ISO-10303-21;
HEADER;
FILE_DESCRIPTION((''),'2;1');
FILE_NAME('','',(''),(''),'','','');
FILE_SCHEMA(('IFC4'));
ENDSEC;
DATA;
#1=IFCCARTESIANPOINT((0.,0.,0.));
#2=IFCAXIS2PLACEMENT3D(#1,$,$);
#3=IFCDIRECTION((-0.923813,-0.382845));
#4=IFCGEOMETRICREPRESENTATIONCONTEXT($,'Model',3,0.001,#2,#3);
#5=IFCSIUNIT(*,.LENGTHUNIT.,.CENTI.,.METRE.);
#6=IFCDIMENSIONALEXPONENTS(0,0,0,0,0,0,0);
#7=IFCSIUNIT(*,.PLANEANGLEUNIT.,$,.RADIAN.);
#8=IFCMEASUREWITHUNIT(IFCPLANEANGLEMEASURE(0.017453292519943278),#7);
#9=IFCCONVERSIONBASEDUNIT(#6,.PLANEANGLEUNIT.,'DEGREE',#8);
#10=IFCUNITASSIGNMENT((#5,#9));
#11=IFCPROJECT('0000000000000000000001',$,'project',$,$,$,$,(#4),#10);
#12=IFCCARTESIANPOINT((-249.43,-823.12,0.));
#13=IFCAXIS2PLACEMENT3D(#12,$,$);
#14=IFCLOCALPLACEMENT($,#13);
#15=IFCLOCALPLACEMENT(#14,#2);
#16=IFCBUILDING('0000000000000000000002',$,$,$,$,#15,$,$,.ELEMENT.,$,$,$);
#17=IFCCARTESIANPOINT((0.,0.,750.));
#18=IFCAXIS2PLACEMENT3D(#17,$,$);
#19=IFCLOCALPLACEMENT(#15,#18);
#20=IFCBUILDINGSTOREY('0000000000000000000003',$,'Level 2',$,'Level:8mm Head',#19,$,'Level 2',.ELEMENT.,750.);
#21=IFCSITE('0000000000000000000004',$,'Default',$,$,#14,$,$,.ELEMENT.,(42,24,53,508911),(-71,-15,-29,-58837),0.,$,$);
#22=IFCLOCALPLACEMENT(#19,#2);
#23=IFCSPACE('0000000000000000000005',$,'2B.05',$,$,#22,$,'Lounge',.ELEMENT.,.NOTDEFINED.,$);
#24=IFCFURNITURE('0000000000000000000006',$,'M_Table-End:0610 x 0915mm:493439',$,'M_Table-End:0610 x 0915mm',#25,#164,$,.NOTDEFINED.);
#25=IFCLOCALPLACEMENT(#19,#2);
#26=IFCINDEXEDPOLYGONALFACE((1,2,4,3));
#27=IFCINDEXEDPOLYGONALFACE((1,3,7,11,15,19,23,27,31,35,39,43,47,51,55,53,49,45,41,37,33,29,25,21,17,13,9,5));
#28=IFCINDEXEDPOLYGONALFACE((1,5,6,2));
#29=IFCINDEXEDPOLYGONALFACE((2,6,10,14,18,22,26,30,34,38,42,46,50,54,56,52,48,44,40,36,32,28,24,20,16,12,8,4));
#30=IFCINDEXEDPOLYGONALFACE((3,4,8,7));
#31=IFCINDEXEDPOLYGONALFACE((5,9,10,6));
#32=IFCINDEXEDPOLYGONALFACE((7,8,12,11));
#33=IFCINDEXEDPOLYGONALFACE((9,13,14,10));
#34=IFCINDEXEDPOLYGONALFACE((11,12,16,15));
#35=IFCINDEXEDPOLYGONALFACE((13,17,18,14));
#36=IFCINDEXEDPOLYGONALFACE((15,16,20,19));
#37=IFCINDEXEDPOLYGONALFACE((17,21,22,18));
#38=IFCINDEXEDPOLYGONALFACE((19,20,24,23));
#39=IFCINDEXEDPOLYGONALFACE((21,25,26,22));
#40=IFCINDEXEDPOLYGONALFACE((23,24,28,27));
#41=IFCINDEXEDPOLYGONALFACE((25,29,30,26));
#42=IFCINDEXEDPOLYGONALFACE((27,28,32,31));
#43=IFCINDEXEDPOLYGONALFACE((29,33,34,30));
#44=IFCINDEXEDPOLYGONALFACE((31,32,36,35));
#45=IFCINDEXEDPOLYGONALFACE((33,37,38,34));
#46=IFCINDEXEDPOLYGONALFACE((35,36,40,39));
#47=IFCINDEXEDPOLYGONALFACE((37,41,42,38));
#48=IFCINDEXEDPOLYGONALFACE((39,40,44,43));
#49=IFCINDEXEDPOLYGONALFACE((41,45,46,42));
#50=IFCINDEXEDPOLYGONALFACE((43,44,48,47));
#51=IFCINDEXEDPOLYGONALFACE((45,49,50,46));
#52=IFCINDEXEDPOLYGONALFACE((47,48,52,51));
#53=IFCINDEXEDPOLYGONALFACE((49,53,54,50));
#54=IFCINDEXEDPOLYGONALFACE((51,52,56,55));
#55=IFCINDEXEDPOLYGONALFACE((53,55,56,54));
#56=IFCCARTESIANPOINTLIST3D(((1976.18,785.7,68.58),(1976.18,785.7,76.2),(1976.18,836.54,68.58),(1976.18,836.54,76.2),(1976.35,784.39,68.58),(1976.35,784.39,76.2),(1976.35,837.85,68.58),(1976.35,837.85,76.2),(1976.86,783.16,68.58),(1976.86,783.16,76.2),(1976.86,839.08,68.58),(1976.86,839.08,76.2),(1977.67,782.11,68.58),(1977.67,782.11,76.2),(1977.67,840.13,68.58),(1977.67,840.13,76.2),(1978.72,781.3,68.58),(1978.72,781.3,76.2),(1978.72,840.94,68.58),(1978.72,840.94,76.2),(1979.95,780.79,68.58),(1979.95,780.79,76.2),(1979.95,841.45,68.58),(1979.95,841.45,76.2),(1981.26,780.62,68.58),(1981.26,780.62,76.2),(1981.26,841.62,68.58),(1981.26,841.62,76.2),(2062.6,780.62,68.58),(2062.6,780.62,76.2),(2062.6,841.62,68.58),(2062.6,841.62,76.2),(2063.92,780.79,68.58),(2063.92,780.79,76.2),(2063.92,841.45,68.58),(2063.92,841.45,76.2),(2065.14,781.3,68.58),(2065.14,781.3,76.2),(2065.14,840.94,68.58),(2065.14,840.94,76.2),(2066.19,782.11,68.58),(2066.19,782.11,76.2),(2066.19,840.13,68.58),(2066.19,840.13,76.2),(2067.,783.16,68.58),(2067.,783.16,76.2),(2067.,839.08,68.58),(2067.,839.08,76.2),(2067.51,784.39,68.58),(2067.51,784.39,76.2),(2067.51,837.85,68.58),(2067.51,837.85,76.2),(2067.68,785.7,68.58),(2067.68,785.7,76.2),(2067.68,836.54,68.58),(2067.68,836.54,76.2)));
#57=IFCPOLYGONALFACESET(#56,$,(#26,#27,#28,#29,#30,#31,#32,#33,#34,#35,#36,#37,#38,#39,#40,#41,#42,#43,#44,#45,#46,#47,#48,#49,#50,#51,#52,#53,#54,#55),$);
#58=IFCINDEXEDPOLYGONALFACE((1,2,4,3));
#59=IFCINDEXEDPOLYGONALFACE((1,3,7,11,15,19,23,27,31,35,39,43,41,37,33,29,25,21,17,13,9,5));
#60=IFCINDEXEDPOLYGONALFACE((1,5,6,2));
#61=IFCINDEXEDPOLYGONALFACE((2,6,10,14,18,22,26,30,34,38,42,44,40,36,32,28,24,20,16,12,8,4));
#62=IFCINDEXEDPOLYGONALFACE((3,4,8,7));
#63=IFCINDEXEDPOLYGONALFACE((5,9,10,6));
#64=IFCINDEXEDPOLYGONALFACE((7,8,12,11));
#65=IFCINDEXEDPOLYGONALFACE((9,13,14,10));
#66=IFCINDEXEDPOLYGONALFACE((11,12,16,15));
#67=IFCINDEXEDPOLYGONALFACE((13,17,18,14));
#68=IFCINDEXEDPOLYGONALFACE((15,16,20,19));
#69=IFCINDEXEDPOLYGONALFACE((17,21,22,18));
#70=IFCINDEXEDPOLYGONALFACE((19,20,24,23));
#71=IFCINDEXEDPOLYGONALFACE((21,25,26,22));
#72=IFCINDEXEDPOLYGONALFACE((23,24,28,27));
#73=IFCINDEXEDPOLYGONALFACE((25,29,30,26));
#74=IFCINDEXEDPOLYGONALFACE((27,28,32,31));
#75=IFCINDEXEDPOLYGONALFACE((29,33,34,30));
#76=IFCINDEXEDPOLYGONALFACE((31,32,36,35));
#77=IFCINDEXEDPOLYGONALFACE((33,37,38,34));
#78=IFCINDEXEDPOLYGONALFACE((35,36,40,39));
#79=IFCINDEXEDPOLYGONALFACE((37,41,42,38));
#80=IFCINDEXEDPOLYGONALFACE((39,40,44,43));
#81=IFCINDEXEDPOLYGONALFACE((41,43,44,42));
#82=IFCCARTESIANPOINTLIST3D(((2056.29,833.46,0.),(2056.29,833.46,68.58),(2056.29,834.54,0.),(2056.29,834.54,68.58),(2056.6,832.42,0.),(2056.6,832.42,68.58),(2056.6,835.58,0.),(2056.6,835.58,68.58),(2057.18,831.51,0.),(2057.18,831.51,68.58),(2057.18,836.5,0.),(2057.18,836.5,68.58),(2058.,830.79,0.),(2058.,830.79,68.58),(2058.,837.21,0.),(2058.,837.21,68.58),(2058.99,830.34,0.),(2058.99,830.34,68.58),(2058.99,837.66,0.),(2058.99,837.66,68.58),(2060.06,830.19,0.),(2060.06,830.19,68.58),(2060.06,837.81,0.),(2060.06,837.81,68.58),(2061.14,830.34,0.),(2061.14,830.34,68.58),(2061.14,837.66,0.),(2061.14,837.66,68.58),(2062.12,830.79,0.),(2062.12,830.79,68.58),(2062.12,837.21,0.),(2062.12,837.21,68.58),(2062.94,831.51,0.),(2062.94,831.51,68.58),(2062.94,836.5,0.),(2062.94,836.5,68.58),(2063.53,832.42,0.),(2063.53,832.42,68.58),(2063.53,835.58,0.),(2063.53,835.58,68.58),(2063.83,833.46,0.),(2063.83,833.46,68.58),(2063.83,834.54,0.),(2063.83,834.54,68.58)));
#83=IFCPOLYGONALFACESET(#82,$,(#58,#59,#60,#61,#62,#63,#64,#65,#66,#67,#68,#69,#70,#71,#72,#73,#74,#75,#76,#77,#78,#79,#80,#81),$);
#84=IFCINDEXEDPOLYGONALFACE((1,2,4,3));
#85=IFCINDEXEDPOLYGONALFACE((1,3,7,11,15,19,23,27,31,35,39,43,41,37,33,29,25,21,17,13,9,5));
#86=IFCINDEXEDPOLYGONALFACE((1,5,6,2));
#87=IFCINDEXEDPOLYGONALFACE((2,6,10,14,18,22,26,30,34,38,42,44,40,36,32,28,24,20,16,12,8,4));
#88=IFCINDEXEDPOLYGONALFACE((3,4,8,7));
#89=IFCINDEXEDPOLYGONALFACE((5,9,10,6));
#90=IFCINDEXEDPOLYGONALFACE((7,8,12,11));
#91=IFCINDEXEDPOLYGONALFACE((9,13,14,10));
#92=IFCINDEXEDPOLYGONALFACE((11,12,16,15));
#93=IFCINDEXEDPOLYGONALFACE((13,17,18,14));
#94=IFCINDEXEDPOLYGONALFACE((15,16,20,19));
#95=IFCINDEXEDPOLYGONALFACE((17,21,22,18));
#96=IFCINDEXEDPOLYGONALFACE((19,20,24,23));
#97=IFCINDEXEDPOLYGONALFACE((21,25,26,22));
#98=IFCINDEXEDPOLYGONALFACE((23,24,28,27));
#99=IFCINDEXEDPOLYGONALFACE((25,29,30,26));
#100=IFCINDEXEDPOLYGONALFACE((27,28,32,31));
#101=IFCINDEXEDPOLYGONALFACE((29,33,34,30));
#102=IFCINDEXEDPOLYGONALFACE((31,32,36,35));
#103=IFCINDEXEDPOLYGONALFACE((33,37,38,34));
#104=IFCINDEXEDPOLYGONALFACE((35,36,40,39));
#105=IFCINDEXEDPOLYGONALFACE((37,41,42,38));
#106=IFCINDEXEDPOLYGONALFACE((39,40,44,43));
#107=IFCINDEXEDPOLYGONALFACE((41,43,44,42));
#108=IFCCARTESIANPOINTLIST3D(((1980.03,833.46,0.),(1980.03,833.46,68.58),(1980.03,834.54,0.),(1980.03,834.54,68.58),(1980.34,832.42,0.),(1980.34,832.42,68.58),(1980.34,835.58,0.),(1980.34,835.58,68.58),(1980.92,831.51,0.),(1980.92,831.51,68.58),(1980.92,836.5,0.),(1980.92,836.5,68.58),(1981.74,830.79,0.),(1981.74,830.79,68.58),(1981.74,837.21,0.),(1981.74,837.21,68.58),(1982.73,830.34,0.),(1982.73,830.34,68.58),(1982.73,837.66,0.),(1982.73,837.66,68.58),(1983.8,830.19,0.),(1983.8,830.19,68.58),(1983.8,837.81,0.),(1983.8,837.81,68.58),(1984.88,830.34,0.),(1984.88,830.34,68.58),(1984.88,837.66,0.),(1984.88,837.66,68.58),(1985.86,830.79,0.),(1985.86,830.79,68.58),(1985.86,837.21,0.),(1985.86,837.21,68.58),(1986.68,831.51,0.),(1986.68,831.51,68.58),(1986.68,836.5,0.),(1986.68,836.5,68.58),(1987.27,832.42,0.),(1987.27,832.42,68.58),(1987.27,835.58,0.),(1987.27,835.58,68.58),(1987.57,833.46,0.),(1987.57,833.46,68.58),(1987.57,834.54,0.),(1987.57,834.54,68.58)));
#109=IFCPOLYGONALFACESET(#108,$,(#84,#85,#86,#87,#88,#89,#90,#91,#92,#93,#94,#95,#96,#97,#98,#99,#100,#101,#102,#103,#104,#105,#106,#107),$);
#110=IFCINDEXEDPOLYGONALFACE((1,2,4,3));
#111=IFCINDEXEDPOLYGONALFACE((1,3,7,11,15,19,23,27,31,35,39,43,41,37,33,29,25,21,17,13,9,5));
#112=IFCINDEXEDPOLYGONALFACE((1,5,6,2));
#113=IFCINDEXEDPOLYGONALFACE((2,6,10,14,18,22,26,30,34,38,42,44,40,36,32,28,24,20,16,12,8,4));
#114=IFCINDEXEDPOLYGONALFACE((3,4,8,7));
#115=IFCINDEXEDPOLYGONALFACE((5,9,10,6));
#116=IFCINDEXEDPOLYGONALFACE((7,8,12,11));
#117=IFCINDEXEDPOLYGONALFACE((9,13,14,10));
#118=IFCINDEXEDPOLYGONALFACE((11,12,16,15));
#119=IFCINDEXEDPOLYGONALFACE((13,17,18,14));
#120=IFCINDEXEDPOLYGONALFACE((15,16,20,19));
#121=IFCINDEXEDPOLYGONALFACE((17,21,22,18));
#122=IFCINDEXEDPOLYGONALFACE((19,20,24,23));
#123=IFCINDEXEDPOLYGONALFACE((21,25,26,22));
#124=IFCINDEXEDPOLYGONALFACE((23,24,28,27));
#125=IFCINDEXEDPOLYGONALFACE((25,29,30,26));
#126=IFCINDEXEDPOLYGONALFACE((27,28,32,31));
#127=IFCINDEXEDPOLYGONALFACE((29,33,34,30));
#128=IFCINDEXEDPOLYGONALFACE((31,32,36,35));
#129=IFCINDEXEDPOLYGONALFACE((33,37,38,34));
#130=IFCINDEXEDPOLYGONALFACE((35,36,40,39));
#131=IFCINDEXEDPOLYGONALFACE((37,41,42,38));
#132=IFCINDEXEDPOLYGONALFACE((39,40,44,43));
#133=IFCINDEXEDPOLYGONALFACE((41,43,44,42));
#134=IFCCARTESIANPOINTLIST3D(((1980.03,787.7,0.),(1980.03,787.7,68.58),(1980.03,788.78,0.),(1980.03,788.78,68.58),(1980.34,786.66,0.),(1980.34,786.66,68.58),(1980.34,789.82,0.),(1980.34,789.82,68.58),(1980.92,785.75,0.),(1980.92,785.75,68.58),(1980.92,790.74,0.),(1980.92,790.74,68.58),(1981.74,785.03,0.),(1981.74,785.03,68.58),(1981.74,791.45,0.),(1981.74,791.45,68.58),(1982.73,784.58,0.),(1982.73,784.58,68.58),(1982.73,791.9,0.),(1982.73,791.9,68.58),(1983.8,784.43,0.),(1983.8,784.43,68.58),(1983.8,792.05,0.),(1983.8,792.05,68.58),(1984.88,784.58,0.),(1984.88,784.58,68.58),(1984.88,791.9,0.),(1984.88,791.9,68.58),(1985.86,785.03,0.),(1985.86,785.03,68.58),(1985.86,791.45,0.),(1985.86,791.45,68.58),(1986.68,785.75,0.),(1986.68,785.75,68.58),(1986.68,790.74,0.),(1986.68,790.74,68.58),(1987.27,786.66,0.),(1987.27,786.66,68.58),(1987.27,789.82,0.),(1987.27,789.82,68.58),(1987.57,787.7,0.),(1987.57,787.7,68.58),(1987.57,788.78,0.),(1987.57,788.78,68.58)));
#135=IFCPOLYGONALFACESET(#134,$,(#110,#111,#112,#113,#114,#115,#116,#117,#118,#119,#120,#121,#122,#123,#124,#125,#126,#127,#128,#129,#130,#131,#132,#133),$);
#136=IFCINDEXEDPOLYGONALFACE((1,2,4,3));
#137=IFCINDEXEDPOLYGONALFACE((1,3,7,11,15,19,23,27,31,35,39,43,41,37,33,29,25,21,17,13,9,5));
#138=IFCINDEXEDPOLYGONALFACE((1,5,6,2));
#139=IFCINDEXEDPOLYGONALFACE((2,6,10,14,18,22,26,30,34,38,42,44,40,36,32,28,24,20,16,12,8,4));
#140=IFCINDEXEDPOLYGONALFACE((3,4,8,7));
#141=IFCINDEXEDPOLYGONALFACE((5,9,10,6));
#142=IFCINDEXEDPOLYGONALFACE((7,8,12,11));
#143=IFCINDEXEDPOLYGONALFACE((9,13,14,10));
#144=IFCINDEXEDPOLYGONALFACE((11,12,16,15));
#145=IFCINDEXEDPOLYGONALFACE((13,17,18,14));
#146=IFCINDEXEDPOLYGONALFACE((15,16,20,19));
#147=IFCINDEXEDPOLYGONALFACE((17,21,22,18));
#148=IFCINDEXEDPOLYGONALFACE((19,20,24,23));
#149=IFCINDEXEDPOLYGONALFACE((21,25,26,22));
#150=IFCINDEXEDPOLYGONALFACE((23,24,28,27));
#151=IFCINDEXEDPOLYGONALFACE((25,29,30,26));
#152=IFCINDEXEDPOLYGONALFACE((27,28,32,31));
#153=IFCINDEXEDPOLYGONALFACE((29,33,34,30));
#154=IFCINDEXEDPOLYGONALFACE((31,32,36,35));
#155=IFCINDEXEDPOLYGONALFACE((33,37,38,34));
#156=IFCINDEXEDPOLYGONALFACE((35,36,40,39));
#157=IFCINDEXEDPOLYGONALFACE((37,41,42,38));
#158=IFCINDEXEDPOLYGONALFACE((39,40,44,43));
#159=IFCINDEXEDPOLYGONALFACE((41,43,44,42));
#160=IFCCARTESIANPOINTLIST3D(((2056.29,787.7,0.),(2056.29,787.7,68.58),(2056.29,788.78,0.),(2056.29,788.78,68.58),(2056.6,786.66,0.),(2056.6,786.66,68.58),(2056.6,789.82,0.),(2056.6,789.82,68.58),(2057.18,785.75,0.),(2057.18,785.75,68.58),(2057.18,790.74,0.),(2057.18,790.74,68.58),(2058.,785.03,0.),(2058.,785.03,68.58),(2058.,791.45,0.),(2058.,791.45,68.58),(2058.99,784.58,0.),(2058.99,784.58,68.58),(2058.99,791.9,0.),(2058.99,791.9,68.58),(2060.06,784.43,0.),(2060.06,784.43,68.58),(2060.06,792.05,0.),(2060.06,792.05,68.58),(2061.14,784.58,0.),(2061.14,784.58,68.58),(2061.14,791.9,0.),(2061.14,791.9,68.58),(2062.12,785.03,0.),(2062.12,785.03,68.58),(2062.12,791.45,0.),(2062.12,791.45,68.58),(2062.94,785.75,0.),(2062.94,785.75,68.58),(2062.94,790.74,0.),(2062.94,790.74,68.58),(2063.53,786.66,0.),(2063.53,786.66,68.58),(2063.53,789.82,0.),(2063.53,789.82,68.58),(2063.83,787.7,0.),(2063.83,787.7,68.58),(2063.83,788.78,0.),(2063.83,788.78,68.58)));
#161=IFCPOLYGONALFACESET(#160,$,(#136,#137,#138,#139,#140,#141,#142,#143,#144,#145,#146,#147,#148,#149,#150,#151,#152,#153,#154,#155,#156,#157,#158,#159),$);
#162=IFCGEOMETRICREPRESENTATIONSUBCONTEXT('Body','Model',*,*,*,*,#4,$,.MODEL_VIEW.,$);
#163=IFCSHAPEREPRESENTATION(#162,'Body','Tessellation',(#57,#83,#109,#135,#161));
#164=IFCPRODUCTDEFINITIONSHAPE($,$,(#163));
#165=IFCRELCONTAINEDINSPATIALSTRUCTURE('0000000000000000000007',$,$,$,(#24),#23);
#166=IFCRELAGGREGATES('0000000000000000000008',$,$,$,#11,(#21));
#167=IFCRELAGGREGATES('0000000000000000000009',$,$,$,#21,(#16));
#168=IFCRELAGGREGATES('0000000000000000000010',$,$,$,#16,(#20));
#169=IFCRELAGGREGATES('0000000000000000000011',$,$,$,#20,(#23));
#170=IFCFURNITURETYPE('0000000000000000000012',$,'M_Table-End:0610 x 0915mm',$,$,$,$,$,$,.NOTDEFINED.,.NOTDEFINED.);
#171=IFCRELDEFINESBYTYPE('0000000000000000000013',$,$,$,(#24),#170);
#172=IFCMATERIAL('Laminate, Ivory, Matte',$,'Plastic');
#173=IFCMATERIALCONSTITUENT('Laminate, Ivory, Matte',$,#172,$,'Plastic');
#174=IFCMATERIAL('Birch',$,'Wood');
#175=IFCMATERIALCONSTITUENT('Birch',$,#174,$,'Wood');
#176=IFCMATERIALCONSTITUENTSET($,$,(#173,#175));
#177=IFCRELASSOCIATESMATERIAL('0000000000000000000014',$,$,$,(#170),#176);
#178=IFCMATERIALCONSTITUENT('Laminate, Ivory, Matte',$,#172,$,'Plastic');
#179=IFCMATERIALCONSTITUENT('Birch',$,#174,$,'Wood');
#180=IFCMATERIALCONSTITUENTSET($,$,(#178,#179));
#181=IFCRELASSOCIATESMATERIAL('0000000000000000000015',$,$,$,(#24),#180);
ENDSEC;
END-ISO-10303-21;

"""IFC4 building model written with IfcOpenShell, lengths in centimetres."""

from ifc_helpers import new_model, entity, si_unit, converted_unit, direction, frame, origin, place, context, subcontext, project, spatial, line, arc, indexed_curve, outline, extrude, source, transform, mapped, material, constituent, constituent_set, type_object, type_shapes, element, save


model = new_model("IFC4")

# Units and contexts
model_context = context("Model", 3, precision=0.001, world=origin(), true_north=direction((-0.923813, -0.382845)))
body_context = subcontext(model_context, "Body", "Model", "MODEL_VIEW")
ifc_project = project(units=[si_unit("LENGTHUNIT", "METRE", prefix="CENTI"), converted_unit("PLANEANGLEUNIT", "DEGREE", entity("IfcPlaneAngleMeasure", 0.017453292519943278), si_unit("PLANEANGLEUNIT", "RADIAN"), dimensions=[0, 0, 0, 0, 0, 0, 0])], contexts=[model_context])

# Site, building, storey
site_placement = place(None, frame((-249.43, -823.12, 0.0)))
site = spatial("IfcSite", under=ifc_project, at=site_placement, Name="Default", CompositionType="ELEMENT", RefLatitude=(42, 24, 53, 508911), RefLongitude=(-71, -15, -29, -58837), RefElevation=0.0)
building_placement = place(site_placement, origin())
building = spatial("IfcBuilding", under=site, at=building_placement, CompositionType="ELEMENT")
storey_placement = place(building_placement, frame((0.0, 0.0, 750.0)))
storey = spatial("IfcBuildingStorey", under=building, at=storey_placement, Name="Level 2", ObjectType="Level:8mm Head", LongName="Level 2", CompositionType="ELEMENT", Elevation=750.0)

# Shared definitions
space_1_placement = place(storey_placement, origin())
space_1 = spatial("IfcSpace", under=storey, at=space_1_placement, Name="2B.05", LongName="Lounge", CompositionType="ELEMENT", PredefinedType="NOTDEFINED")

# Furniture
ifc_material_1 = material(Name="Laminate, Ivory, Matte", Category="Plastic")
ifc_constituent_1 = constituent(ifc_material_1, Name="Laminate, Ivory, Matte", Category="Plastic")
ifc_material_2 = material(Name="Birch", Category="Wood")
ifc_constituent_2 = constituent(ifc_material_2, Name="Birch", Category="Wood")
ifc_constituent_set_1 = constituent_set(constituents=[ifc_constituent_1, ifc_constituent_2])
ifc_constituent_3 = constituent(ifc_material_1, Name="Laminate, Ivory, Matte", Category="Plastic")
ifc_constituent_4 = constituent(ifc_material_2, Name="Birch", Category="Wood")
ifc_constituent_set_2 = constituent_set(constituents=[ifc_constituent_3, ifc_constituent_4])
furniture_type_1 = type_object("IfcFurnitureType", Name="M_Table-End:0610 x 0915mm", AssemblyPlace="NOTDEFINED", PredefinedType="NOTDEFINED", material=ifc_constituent_set_2)
shared_shape_1 = source(origin(), body_context, "Body", "SweptSolid", [
    extrude(outline(indexed_curve([(25.42, -45.75), (29.01, -44.26), (30.5, -40.67), (30.5, 40.67), (29.01, 44.26), (25.42, 45.75), (-25.42, 45.75), (-29.01, 44.26), (-30.5, 40.67), (-30.5, -40.67), (-29.01, -44.26), (-25.42, -45.75)], segments=[arc(1, 2, 3), line(3, 4), arc(4, 5, 6), line(6, 7), arc(7, 8, 9), line(9, 10), arc(10, 11, 12), line(12, 1)], self_intersect=False)), frame((30.87, 15.24, -381.42)), (0.0, 0.0, 1.0), 7.62),
    extrude(outline(indexed_curve([(-3.81, 0.0), (0.0, -3.81), (3.81, 0.0), (0.0, 3.81)], segments=[arc(1, 2, 3), arc(3, 4, 1)], self_intersect=False)), frame((53.75, -22.89, -450.0)), (0.0, 0.0, 1.0), 68.58),
    extrude(outline(indexed_curve([(-3.81, 0.0), (0.0, -3.81), (3.81, 0.0), (0.0, 3.81)], segments=[arc(1, 2, 3), arc(3, 4, 1)], self_intersect=False)), frame((53.75, 53.37, -450.0)), (0.0, 0.0, 1.0), 68.58),
    extrude(outline(indexed_curve([(-3.81, 0.0), (0.0, -3.81), (3.81, 0.0), (0.0, 3.81)], segments=[arc(1, 2, 3), arc(3, 4, 1)], self_intersect=False)), frame((7.99, 53.37, -450.0)), (0.0, 0.0, 1.0), 68.58),
    extrude(outline(indexed_curve([(-3.81, 0.0), (0.0, -3.81), (3.81, 0.0), (0.0, 3.81)], segments=[arc(1, 2, 3), arc(3, 4, 1)], self_intersect=False)), frame((7.99, -22.89, -450.0)), (0.0, 0.0, 1.0), 68.58),
])
type_shapes(furniture_type_1, [shared_shape_1])
furniture_1_placement = place(space_1_placement, frame((2037.17, 780.25, 450.0), z_axis=(0.0, 0.0, 1.0), x_axis=(0.0, 1.0, 0.0)))
element("IfcFurniture", 1, at=furniture_1_placement, inside=space_1, type_object=furniture_type_1, material=ifc_constituent_set_1, Name="M_Table-End:0610 x 0915mm:493439", ObjectType="M_Table-End:0610 x 0915mm", PredefinedType="NOTDEFINED", context=body_context, shape_type="MappedRepresentation", body=[
    mapped(shared_shape_1, transform((0.0, 0.0, 0.0), scale=1.0)),
])

save(model, "model.ifc")
